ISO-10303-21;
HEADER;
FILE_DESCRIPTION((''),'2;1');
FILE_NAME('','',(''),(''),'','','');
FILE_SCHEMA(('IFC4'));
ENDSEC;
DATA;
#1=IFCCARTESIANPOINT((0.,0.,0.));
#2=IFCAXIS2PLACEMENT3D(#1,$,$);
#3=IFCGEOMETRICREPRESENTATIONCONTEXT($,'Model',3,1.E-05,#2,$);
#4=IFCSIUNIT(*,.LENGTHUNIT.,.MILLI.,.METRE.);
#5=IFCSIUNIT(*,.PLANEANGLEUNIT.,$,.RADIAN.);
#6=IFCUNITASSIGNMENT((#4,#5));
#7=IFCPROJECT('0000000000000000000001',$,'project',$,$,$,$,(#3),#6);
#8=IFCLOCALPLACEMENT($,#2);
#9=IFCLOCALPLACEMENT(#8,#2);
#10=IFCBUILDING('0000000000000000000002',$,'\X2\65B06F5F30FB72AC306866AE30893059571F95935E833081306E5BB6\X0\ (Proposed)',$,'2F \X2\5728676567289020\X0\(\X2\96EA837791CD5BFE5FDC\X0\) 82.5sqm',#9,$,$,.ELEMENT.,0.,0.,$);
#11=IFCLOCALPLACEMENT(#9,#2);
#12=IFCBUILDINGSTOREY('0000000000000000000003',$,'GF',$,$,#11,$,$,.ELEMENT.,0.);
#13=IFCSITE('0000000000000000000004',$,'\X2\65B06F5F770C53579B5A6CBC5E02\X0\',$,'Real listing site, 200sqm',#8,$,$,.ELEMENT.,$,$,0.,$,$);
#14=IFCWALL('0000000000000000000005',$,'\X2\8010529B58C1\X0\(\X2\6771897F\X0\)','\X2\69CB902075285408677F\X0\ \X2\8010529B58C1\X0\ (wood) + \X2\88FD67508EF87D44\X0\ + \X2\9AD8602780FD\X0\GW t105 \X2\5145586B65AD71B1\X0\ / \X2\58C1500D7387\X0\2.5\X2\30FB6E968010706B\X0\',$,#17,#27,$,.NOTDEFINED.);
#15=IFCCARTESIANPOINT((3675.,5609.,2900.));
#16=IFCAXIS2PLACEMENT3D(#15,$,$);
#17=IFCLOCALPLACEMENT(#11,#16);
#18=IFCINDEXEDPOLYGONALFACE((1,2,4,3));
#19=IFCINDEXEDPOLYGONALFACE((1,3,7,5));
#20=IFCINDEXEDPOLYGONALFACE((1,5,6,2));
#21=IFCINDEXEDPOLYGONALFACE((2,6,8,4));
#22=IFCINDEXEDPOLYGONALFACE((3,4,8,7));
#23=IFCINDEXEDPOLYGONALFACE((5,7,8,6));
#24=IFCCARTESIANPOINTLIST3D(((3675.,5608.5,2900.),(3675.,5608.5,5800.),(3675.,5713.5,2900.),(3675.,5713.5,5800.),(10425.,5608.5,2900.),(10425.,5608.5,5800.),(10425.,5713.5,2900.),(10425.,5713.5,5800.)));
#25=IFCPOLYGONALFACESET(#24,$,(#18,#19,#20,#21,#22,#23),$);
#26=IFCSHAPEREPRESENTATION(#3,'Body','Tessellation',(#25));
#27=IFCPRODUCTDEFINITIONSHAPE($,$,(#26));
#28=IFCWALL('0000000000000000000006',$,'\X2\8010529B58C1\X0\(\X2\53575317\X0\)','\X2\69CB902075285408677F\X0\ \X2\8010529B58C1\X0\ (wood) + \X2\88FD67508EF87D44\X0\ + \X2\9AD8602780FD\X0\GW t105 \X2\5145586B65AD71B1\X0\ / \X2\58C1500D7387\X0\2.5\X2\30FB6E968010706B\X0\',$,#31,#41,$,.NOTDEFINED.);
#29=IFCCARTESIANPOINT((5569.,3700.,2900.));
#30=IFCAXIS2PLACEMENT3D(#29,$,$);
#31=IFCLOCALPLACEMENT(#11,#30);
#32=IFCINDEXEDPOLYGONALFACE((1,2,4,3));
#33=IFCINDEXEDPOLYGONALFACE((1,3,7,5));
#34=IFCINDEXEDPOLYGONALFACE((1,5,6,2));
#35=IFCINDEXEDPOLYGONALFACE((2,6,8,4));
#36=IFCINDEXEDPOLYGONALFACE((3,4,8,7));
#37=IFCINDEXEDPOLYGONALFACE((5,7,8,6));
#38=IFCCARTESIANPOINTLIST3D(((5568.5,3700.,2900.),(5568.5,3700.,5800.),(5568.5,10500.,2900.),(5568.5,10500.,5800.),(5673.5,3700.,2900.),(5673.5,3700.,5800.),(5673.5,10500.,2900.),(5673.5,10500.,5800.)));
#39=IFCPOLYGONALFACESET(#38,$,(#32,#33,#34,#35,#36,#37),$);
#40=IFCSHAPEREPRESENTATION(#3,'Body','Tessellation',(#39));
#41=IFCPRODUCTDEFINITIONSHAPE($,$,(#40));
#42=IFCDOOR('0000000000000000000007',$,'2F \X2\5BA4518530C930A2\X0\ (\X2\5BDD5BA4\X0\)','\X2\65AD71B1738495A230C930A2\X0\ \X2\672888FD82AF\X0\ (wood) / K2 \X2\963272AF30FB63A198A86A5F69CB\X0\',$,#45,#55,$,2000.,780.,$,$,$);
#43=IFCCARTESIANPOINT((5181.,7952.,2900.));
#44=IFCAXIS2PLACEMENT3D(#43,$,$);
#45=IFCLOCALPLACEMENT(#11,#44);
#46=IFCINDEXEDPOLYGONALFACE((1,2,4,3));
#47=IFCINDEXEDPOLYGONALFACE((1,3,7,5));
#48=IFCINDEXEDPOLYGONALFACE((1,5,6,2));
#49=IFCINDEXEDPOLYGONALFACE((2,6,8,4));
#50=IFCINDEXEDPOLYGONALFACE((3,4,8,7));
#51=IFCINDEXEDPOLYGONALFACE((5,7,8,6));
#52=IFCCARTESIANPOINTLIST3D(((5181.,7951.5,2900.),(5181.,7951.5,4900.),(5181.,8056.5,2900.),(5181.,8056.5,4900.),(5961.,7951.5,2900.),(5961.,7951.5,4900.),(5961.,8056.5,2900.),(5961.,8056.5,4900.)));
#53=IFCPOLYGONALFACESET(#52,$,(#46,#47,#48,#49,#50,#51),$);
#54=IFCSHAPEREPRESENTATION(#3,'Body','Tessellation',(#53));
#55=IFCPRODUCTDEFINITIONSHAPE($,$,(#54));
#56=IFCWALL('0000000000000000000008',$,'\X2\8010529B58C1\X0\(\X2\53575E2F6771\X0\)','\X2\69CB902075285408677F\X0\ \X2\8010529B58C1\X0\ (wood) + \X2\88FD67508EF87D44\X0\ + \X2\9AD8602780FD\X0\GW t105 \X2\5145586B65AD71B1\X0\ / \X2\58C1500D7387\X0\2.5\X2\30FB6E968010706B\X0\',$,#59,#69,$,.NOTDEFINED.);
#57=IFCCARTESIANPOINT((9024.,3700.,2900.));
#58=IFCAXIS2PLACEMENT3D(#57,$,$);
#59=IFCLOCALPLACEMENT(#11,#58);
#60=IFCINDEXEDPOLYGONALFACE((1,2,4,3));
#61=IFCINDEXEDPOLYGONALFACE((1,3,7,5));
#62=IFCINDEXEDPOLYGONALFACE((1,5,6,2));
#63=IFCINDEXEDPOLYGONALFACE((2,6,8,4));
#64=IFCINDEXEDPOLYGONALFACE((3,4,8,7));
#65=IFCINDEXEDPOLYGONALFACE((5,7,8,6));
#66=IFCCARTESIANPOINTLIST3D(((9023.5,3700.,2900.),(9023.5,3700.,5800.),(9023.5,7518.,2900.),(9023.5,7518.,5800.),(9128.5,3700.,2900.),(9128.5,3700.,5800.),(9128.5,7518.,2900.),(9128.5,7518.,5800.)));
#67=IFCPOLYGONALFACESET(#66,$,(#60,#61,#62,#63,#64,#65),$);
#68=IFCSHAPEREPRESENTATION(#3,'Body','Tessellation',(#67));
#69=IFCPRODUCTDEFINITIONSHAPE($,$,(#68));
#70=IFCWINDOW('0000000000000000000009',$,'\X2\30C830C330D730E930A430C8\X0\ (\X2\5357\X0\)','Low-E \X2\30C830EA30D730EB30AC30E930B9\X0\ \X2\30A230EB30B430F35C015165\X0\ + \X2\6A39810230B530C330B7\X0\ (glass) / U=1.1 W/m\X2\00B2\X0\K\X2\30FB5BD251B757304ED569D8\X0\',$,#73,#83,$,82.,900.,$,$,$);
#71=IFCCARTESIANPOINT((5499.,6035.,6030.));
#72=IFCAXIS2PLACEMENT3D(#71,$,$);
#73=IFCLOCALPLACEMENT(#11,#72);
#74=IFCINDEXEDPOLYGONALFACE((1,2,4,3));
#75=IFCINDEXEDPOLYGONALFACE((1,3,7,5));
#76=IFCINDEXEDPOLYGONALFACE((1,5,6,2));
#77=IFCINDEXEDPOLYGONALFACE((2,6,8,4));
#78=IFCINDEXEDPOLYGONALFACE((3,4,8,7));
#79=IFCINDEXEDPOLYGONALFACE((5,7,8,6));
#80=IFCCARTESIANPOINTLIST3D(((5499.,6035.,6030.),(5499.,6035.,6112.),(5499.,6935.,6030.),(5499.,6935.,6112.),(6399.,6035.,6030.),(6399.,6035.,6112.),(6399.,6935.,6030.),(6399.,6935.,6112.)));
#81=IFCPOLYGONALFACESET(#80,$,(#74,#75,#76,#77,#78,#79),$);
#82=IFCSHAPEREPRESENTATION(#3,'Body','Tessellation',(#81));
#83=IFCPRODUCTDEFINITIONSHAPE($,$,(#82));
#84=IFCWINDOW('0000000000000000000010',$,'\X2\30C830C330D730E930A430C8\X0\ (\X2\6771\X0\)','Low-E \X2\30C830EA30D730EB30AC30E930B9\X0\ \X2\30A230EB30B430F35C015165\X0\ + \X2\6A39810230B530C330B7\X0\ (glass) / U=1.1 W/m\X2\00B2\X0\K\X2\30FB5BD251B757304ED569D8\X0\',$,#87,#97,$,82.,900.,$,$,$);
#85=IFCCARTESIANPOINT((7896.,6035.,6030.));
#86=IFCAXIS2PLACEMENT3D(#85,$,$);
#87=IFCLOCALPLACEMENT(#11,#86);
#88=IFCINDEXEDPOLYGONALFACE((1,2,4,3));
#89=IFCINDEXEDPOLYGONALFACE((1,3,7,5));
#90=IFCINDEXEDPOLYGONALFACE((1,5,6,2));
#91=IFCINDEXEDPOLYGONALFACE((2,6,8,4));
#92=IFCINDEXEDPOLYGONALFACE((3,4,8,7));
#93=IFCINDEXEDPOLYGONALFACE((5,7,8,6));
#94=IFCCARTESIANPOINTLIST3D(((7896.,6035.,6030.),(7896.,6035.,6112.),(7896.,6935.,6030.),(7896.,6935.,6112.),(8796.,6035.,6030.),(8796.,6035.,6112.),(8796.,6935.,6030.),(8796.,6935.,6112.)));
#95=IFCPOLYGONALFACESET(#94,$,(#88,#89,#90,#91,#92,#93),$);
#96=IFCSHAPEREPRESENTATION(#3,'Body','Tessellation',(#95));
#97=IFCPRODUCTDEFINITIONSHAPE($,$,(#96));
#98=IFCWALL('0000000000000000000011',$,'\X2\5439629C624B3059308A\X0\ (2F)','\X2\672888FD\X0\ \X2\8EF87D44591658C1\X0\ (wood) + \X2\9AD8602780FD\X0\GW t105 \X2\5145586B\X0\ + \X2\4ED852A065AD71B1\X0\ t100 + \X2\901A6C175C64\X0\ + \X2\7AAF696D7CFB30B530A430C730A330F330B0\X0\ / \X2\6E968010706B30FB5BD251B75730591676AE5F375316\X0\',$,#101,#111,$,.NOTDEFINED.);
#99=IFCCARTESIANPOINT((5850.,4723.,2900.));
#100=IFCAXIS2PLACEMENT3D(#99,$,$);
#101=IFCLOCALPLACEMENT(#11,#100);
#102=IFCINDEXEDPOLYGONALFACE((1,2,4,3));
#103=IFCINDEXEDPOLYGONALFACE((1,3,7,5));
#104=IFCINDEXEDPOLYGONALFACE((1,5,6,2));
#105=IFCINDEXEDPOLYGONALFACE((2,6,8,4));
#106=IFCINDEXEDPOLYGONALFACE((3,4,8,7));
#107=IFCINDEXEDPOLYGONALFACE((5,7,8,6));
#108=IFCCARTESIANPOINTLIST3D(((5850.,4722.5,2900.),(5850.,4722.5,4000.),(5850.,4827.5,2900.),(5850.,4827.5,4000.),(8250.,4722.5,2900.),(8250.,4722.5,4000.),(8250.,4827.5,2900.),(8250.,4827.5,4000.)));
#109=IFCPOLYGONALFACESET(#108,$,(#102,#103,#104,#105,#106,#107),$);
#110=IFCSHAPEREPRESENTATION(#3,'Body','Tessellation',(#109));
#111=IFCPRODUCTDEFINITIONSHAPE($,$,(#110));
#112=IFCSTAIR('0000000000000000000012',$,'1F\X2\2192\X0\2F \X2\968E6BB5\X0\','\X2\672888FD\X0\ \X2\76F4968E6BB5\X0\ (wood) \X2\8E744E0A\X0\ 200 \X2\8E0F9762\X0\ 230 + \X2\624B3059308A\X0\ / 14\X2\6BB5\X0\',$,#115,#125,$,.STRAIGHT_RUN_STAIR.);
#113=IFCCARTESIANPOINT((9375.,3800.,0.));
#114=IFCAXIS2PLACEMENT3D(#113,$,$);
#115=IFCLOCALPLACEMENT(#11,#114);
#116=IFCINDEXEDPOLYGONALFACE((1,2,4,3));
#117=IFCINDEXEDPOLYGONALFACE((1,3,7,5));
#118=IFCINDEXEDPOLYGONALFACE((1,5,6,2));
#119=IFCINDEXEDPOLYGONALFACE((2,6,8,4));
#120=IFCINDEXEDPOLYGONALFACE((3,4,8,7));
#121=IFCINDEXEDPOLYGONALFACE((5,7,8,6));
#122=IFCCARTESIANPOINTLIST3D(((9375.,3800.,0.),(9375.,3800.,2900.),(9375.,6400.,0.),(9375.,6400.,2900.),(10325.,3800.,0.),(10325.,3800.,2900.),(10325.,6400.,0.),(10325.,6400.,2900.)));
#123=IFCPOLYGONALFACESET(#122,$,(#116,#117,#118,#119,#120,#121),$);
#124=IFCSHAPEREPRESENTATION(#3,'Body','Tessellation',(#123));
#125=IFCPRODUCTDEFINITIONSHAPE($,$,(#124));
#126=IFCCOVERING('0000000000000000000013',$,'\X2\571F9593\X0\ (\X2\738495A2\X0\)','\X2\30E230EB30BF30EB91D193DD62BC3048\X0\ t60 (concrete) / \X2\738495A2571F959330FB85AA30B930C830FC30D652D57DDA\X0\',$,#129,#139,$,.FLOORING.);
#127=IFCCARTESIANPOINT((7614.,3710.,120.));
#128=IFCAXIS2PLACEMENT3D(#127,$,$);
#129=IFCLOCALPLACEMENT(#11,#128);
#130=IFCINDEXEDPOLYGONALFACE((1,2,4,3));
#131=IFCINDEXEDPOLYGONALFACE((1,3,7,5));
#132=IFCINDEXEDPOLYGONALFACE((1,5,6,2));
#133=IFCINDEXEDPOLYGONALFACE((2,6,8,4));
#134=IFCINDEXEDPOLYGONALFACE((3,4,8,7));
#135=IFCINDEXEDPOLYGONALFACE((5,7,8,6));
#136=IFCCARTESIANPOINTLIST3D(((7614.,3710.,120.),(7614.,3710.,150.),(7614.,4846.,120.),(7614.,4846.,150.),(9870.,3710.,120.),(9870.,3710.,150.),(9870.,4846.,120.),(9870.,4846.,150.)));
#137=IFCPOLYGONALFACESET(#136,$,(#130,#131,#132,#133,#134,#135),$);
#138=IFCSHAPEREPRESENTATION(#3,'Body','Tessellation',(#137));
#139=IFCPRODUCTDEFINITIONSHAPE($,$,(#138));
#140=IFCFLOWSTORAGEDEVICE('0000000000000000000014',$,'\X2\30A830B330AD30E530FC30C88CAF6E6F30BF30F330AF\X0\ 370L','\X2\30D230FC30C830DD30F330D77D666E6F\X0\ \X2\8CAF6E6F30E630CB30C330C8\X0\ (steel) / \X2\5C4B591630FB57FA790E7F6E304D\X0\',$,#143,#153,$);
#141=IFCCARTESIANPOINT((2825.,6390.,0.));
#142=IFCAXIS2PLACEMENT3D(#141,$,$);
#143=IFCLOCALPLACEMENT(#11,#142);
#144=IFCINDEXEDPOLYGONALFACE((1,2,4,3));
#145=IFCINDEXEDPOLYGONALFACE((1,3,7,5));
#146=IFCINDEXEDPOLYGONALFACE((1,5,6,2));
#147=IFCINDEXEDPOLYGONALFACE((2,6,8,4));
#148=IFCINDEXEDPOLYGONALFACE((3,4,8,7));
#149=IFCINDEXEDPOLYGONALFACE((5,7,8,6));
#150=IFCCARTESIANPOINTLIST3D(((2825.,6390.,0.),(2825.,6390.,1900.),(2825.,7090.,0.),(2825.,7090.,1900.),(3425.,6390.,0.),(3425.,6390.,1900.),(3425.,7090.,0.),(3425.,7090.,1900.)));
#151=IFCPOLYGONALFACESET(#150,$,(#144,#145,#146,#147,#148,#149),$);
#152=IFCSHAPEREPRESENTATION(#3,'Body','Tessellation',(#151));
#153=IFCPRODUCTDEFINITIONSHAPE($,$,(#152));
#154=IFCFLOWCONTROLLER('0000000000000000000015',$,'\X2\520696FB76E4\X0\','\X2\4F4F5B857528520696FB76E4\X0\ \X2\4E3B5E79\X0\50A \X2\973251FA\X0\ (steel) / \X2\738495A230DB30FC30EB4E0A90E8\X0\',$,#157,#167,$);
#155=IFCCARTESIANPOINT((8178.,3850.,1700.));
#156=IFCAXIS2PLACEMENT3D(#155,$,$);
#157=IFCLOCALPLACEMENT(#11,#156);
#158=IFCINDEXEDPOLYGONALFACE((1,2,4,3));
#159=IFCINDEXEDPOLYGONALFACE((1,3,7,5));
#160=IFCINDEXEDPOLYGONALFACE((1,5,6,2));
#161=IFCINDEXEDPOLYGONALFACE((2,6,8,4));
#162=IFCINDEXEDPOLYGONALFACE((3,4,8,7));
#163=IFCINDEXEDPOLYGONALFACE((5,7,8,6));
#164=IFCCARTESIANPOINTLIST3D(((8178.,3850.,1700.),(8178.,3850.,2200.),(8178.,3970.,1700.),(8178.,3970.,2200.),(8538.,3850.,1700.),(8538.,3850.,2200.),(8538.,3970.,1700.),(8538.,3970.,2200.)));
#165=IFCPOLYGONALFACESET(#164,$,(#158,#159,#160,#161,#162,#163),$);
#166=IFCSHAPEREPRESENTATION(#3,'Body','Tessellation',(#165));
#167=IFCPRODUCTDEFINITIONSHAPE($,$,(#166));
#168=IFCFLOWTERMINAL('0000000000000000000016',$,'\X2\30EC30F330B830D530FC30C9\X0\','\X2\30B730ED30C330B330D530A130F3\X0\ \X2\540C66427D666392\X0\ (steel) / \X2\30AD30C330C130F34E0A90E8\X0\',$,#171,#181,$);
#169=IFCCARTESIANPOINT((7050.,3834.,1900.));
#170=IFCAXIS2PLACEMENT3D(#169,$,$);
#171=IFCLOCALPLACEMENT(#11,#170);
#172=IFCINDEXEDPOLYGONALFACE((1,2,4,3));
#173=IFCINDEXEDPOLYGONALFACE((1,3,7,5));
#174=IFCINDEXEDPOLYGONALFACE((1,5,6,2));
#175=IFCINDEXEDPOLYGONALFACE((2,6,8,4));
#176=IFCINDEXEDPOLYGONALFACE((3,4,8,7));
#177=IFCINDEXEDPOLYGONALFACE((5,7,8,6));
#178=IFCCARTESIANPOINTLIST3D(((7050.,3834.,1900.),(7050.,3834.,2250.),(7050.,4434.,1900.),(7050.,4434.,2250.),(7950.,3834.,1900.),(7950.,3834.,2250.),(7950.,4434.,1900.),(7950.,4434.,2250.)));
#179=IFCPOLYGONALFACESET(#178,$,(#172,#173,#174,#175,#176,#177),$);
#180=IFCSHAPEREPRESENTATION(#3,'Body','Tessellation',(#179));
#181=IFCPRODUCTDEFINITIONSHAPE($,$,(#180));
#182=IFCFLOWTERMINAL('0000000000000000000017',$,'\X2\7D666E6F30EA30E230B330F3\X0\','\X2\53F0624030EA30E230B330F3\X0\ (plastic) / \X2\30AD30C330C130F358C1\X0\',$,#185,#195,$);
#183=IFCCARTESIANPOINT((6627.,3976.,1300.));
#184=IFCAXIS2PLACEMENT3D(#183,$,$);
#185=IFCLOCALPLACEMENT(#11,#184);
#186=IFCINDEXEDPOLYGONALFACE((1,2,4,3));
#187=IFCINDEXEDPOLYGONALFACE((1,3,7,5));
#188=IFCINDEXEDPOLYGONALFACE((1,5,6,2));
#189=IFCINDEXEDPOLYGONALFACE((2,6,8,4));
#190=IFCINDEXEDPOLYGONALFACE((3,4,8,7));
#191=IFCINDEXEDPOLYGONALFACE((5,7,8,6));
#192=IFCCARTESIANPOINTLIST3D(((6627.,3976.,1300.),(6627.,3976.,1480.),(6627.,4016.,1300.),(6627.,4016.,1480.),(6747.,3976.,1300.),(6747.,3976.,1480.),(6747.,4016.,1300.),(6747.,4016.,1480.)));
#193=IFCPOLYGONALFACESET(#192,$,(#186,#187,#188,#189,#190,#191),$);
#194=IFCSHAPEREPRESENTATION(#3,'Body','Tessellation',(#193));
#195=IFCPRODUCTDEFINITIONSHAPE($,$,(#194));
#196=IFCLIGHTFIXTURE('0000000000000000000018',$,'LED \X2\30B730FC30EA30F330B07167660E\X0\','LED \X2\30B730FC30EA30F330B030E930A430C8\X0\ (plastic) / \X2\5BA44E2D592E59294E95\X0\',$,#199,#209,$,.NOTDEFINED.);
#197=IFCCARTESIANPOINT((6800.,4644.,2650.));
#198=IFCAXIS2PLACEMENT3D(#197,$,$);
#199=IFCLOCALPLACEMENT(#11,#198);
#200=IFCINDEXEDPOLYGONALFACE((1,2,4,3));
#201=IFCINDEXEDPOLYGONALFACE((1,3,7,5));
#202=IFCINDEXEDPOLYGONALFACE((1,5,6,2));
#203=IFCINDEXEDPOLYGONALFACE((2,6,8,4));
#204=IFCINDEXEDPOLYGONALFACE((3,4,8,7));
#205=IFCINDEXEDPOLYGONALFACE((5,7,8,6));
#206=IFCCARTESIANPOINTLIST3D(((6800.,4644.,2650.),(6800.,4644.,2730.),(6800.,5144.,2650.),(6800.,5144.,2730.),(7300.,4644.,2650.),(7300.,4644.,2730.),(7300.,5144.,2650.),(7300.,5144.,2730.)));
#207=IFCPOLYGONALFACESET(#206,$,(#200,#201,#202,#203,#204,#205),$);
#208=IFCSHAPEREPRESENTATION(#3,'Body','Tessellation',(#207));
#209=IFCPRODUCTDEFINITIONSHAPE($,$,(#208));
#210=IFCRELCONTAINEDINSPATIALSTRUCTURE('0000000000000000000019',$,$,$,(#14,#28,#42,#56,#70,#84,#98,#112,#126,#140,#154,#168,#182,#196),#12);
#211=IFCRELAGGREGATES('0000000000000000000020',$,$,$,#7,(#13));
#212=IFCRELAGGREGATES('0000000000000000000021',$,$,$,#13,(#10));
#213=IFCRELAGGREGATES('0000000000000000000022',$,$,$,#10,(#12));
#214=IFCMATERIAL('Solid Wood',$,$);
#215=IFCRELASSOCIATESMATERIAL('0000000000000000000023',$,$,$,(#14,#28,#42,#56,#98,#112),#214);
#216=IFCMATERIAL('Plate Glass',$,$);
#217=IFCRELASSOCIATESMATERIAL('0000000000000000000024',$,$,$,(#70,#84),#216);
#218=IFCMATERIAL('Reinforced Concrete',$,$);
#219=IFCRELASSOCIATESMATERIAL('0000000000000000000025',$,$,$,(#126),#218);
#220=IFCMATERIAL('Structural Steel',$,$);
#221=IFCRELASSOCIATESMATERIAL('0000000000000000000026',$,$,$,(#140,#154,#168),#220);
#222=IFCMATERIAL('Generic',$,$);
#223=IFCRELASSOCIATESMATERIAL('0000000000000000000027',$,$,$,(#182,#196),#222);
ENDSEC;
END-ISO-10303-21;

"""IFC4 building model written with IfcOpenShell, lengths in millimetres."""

from ifc_helpers import new_model, si_unit, frame, frame_2d, origin, place, context, project, spatial, rectangle, extrude, material, element, fill, save


model = new_model("IFC4")

# Units and contexts
model_context = context("Model", 3, precision=1e-05, world=origin())
ifc_project = project(units=[si_unit("LENGTHUNIT", "METRE", prefix="MILLI"), si_unit("PLANEANGLEUNIT", "RADIAN")], contexts=[model_context])

# Site, building, storey
site_placement = place(None, origin())
site = spatial("IfcSite", under=ifc_project, at=site_placement, Name="新潟県南魚沼市", ObjectType="Real listing site, 200sqm", CompositionType="ELEMENT", RefElevation=0.0)
building_placement = place(site_placement, origin())
building = spatial("IfcBuilding", under=site, at=building_placement, Name="新潟・犬と暮らす土間広めの家 (Proposed)", ObjectType="2F 在来木造(雪荷重対応) 82.5sqm", CompositionType="ELEMENT", ElevationOfRefHeight=0.0, ElevationOfTerrain=0.0)
storey_placement = place(building_placement, origin())
storey = spatial("IfcBuildingStorey", under=building, at=storey_placement, Name="GF", CompositionType="ELEMENT", Elevation=0.0)

# Shared definitions
ifc_material_1 = material(Name="Solid Wood")

# Wall
wall_1_placement = place(storey_placement, frame((3675.0, 5609.0, 2900.0)))
element("IfcWall", 1, at=wall_1_placement, inside=storey, material=ifc_material_1, Name="耐力壁(東西)", Description="構造用合板 耐力壁 (wood) + 製材軸組 + 高性能GW t105 充填断熱 / 壁倍率2.5・準耐火", PredefinedType="NOTDEFINED", context=model_context, shape_type="SweptSolid", body=[
    extrude(rectangle(XDim=6750.0, YDim=105.0, at=frame_2d((3375.0, 52.0))), frame((3675.0, 5609.0, 2900.0)), (0.0, 0.0, 1.0), 2900.0),
])

# Wall, opening, door
wall_2_placement = place(storey_placement, frame((5569.0, 3700.0, 2900.0)))
wall_2 = element("IfcWall", 2, at=wall_2_placement, inside=storey, material=ifc_material_1, Name="耐力壁(南北)", Description="構造用合板 耐力壁 (wood) + 製材軸組 + 高性能GW t105 充填断熱 / 壁倍率2.5・準耐火", PredefinedType="NOTDEFINED", context=model_context, shape_type="SweptSolid", body=[
    extrude(rectangle(XDim=105.0, YDim=6800.0, at=frame_2d((52.0, 3400.0))), frame((5569.0, 3700.0, 2900.0)), (0.0, 0.0, 1.0), 2900.0),
])
opening_placement = place(storey_placement, frame((5181.0, 7952.0, 2900.0)))
opening = element("IfcOpeningElement", 3, at=opening_placement, cuts=wall_2, PredefinedType="NOTDEFINED", context=model_context, shape_type="SweptSolid", body=[
    extrude(rectangle(XDim=780.0, YDim=105.0, at=frame_2d((390.0, 52.0))), frame((5181.0, 7952.0, 2900.0)), (0.0, 0.0, 1.0), 2000.0),
])
door_placement = place(storey_placement, frame((5181.0, 7952.0, 2900.0)))
door = element("IfcDoor", 4, at=door_placement, inside=storey, material=ifc_material_1, Name="2F 室内ドア (寝室)", Description="断熱玄関ドア 木製芯 (wood) / K2 防犯・採風機構", OverallHeight=2000.0, OverallWidth=780.0, context=model_context, shape_type="SweptSolid", body=[
    extrude(rectangle(XDim=780.0, YDim=105.0, at=frame_2d((390.0, 52.0))), frame((5181.0, 7952.0, 2900.0)), (0.0, 0.0, 1.0), 2000.0),
])
fill(opening, door)

# Wall
wall_3_placement = place(storey_placement, frame((9024.0, 3700.0, 2900.0)))
element("IfcWall", 5, at=wall_3_placement, inside=storey, material=ifc_material_1, Name="耐力壁(南帯東)", Description="構造用合板 耐力壁 (wood) + 製材軸組 + 高性能GW t105 充填断熱 / 壁倍率2.5・準耐火", PredefinedType="NOTDEFINED", context=model_context, shape_type="SweptSolid", body=[
    extrude(rectangle(XDim=105.0, YDim=3818.0, at=frame_2d((52.0, 1909.0))), frame((9024.0, 3700.0, 2900.0)), (0.0, 0.0, 1.0), 2900.0),
])

# Windows
ifc_material_2 = material(Name="Plate Glass")
window_1_placement = place(storey_placement, frame((5499.0, 6035.0, 6030.0)))
element("IfcWindow", 6, at=window_1_placement, inside=storey, material=ifc_material_2, Name="トップライト (南)", Description="Low-E トリプルガラス アルゴン封入 + 樹脂サッシ (glass) / U=1.1 W/m²K・寒冷地仕様", OverallHeight=82.0, OverallWidth=900.0, context=model_context, shape_type="SweptSolid", body=[
    extrude(rectangle(XDim=900.0, YDim=900.0, at=frame_2d((450.0, 450.0))), frame((5499.0, 6035.0, 6030.0)), (0.0, 0.0, 1.0), 82.0),
])
window_2_placement = place(storey_placement, frame((7896.0, 6035.0, 6030.0)))
element("IfcWindow", 7, at=window_2_placement, inside=storey, material=ifc_material_2, Name="トップライト (東)", Description="Low-E トリプルガラス アルゴン封入 + 樹脂サッシ (glass) / U=1.1 W/m²K・寒冷地仕様", OverallHeight=82.0, OverallWidth=900.0, context=model_context, shape_type="SweptSolid", body=[
    extrude(rectangle(XDim=900.0, YDim=900.0, at=frame_2d((450.0, 450.0))), frame((7896.0, 6035.0, 6030.0)), (0.0, 0.0, 1.0), 82.0),
])

# Wall
wall_4_placement = place(storey_placement, frame((5850.0, 4723.0, 2900.0)))
element("IfcWall", 8, at=wall_4_placement, inside=storey, material=ifc_material_1, Name="吹抜手すり (2F)", Description="木製 軸組外壁 (wood) + 高性能GW t105 充填 + 付加断熱 t100 + 通気層 + 窯業系サイディング / 準耐火・寒冷地外皮強化", PredefinedType="NOTDEFINED", context=model_context, shape_type="SweptSolid", body=[
    extrude(rectangle(XDim=2400.0, YDim=105.0, at=frame_2d((1200.0, 52.0))), frame((5850.0, 4723.0, 2900.0)), (0.0, 0.0, 1.0), 1100.0),
])

# Stair
stair_placement = place(storey_placement, frame((9375.0, 3800.0, 0.0)))
element("IfcStair", 9, at=stair_placement, inside=storey, material=ifc_material_1, Name="1F→2F 階段", Description="木製 直階段 (wood) 蹴上 200 踏面 230 + 手すり / 14段", PredefinedType="STRAIGHT_RUN_STAIR", context=model_context, shape_type="SweptSolid", body=[
    extrude(rectangle(XDim=950.0, YDim=2600.0, at=frame_2d((475.0, 1300.0))), frame((9375.0, 3800.0, 0.0)), (0.0, 0.0, 1.0), 2900.0),
])

# Covering
ifc_material_3 = material(Name="Reinforced Concrete")
covering_placement = place(storey_placement, frame((7614.0, 3710.0, 120.0)))
element("IfcCovering", 10, at=covering_placement, inside=storey, material=ifc_material_3, Name="土間 (玄関)", Description="モルタル金鏝押え t60 (concrete) / 玄関土間・薪ストーブ動線", PredefinedType="FLOORING", context=model_context, shape_type="SweptSolid", body=[
    extrude(rectangle(XDim=2256.0, YDim=1136.0, at=frame_2d((1128.0, 568.0))), frame((7614.0, 3710.0, 120.0)), (0.0, 0.0, 1.0), 30.0),
])

# Flow storage device
ifc_material_4 = material(Name="Structural Steel")
flow_storage_device_placement = place(storey_placement, frame((2825.0, 6390.0, 0.0)))
element("IfcFlowStorageDevice", 11, at=flow_storage_device_placement, inside=storey, material=ifc_material_4, Name="エコキュート貯湯タンク 370L", Description="ヒートポンプ給湯 貯湯ユニット (steel) / 屋外・基礎置き", context=model_context, shape_type="SweptSolid", body=[
    extrude(rectangle(XDim=600.0, YDim=700.0, at=frame_2d((300.0, 350.0))), frame((2825.0, 6390.0, 0.0)), (0.0, 0.0, 1.0), 1900.0),
])

# Flow controller
flow_controller_placement = place(storey_placement, frame((8178.0, 3850.0, 1700.0)))
element("IfcFlowController", 12, at=flow_controller_placement, inside=storey, material=ifc_material_4, Name="分電盤", Description="住宅用分電盤 主幹50A 露出 (steel) / 玄関ホール上部", context=model_context, shape_type="SweptSolid", body=[
    extrude(rectangle(XDim=360.0, YDim=120.0, at=frame_2d((180.0, 60.0))), frame((8178.0, 3850.0, 1700.0)), (0.0, 0.0, 1.0), 500.0),
])

# Flow terminals
flow_terminal_1_placement = place(storey_placement, frame((7050.0, 3834.0, 1900.0)))
element("IfcFlowTerminal", 13, at=flow_terminal_1_placement, inside=storey, material=ifc_material_4, Name="レンジフード", Description="シロッコファン 同時給排 (steel) / キッチン上部", context=model_context, shape_type="SweptSolid", body=[
    extrude(rectangle(XDim=900.0, YDim=600.0, at=frame_2d((450.0, 300.0))), frame((7050.0, 3834.0, 1900.0)), (0.0, 0.0, 1.0), 350.0),
])
ifc_material_5 = material(Name="Generic")
flow_terminal_2_placement = place(storey_placement, frame((6627.0, 3976.0, 1300.0)))
element("IfcFlowTerminal", 14, at=flow_terminal_2_placement, inside=storey, material=ifc_material_5, Name="給湯リモコン", Description="台所リモコン (plastic) / キッチン壁", context=model_context, shape_type="SweptSolid", body=[
    extrude(rectangle(XDim=120.0, YDim=40.0, at=frame_2d((60.0, 20.0))), frame((6627.0, 3976.0, 1300.0)), (0.0, 0.0, 1.0), 180.0),
])

# Light fixture
light_fixture_1_placement = place(storey_placement, frame((6800.0, 4644.0, 2650.0)))
element("IfcLightFixture", 15, at=light_fixture_1_placement, inside=storey, material=ifc_material_5, Name="LED シーリング照明", Description="LED シーリングライト (plastic) / 室中央天井", PredefinedType="NOTDEFINED", context=model_context, shape_type="SweptSolid", body=[
    extrude(rectangle(XDim=500.0, YDim=500.0, at=frame_2d((250.0, 250.0))), frame((6800.0, 4644.0, 2650.0)), (0.0, 0.0, 1.0), 80.0),
])

save(model, "model.ifc")
